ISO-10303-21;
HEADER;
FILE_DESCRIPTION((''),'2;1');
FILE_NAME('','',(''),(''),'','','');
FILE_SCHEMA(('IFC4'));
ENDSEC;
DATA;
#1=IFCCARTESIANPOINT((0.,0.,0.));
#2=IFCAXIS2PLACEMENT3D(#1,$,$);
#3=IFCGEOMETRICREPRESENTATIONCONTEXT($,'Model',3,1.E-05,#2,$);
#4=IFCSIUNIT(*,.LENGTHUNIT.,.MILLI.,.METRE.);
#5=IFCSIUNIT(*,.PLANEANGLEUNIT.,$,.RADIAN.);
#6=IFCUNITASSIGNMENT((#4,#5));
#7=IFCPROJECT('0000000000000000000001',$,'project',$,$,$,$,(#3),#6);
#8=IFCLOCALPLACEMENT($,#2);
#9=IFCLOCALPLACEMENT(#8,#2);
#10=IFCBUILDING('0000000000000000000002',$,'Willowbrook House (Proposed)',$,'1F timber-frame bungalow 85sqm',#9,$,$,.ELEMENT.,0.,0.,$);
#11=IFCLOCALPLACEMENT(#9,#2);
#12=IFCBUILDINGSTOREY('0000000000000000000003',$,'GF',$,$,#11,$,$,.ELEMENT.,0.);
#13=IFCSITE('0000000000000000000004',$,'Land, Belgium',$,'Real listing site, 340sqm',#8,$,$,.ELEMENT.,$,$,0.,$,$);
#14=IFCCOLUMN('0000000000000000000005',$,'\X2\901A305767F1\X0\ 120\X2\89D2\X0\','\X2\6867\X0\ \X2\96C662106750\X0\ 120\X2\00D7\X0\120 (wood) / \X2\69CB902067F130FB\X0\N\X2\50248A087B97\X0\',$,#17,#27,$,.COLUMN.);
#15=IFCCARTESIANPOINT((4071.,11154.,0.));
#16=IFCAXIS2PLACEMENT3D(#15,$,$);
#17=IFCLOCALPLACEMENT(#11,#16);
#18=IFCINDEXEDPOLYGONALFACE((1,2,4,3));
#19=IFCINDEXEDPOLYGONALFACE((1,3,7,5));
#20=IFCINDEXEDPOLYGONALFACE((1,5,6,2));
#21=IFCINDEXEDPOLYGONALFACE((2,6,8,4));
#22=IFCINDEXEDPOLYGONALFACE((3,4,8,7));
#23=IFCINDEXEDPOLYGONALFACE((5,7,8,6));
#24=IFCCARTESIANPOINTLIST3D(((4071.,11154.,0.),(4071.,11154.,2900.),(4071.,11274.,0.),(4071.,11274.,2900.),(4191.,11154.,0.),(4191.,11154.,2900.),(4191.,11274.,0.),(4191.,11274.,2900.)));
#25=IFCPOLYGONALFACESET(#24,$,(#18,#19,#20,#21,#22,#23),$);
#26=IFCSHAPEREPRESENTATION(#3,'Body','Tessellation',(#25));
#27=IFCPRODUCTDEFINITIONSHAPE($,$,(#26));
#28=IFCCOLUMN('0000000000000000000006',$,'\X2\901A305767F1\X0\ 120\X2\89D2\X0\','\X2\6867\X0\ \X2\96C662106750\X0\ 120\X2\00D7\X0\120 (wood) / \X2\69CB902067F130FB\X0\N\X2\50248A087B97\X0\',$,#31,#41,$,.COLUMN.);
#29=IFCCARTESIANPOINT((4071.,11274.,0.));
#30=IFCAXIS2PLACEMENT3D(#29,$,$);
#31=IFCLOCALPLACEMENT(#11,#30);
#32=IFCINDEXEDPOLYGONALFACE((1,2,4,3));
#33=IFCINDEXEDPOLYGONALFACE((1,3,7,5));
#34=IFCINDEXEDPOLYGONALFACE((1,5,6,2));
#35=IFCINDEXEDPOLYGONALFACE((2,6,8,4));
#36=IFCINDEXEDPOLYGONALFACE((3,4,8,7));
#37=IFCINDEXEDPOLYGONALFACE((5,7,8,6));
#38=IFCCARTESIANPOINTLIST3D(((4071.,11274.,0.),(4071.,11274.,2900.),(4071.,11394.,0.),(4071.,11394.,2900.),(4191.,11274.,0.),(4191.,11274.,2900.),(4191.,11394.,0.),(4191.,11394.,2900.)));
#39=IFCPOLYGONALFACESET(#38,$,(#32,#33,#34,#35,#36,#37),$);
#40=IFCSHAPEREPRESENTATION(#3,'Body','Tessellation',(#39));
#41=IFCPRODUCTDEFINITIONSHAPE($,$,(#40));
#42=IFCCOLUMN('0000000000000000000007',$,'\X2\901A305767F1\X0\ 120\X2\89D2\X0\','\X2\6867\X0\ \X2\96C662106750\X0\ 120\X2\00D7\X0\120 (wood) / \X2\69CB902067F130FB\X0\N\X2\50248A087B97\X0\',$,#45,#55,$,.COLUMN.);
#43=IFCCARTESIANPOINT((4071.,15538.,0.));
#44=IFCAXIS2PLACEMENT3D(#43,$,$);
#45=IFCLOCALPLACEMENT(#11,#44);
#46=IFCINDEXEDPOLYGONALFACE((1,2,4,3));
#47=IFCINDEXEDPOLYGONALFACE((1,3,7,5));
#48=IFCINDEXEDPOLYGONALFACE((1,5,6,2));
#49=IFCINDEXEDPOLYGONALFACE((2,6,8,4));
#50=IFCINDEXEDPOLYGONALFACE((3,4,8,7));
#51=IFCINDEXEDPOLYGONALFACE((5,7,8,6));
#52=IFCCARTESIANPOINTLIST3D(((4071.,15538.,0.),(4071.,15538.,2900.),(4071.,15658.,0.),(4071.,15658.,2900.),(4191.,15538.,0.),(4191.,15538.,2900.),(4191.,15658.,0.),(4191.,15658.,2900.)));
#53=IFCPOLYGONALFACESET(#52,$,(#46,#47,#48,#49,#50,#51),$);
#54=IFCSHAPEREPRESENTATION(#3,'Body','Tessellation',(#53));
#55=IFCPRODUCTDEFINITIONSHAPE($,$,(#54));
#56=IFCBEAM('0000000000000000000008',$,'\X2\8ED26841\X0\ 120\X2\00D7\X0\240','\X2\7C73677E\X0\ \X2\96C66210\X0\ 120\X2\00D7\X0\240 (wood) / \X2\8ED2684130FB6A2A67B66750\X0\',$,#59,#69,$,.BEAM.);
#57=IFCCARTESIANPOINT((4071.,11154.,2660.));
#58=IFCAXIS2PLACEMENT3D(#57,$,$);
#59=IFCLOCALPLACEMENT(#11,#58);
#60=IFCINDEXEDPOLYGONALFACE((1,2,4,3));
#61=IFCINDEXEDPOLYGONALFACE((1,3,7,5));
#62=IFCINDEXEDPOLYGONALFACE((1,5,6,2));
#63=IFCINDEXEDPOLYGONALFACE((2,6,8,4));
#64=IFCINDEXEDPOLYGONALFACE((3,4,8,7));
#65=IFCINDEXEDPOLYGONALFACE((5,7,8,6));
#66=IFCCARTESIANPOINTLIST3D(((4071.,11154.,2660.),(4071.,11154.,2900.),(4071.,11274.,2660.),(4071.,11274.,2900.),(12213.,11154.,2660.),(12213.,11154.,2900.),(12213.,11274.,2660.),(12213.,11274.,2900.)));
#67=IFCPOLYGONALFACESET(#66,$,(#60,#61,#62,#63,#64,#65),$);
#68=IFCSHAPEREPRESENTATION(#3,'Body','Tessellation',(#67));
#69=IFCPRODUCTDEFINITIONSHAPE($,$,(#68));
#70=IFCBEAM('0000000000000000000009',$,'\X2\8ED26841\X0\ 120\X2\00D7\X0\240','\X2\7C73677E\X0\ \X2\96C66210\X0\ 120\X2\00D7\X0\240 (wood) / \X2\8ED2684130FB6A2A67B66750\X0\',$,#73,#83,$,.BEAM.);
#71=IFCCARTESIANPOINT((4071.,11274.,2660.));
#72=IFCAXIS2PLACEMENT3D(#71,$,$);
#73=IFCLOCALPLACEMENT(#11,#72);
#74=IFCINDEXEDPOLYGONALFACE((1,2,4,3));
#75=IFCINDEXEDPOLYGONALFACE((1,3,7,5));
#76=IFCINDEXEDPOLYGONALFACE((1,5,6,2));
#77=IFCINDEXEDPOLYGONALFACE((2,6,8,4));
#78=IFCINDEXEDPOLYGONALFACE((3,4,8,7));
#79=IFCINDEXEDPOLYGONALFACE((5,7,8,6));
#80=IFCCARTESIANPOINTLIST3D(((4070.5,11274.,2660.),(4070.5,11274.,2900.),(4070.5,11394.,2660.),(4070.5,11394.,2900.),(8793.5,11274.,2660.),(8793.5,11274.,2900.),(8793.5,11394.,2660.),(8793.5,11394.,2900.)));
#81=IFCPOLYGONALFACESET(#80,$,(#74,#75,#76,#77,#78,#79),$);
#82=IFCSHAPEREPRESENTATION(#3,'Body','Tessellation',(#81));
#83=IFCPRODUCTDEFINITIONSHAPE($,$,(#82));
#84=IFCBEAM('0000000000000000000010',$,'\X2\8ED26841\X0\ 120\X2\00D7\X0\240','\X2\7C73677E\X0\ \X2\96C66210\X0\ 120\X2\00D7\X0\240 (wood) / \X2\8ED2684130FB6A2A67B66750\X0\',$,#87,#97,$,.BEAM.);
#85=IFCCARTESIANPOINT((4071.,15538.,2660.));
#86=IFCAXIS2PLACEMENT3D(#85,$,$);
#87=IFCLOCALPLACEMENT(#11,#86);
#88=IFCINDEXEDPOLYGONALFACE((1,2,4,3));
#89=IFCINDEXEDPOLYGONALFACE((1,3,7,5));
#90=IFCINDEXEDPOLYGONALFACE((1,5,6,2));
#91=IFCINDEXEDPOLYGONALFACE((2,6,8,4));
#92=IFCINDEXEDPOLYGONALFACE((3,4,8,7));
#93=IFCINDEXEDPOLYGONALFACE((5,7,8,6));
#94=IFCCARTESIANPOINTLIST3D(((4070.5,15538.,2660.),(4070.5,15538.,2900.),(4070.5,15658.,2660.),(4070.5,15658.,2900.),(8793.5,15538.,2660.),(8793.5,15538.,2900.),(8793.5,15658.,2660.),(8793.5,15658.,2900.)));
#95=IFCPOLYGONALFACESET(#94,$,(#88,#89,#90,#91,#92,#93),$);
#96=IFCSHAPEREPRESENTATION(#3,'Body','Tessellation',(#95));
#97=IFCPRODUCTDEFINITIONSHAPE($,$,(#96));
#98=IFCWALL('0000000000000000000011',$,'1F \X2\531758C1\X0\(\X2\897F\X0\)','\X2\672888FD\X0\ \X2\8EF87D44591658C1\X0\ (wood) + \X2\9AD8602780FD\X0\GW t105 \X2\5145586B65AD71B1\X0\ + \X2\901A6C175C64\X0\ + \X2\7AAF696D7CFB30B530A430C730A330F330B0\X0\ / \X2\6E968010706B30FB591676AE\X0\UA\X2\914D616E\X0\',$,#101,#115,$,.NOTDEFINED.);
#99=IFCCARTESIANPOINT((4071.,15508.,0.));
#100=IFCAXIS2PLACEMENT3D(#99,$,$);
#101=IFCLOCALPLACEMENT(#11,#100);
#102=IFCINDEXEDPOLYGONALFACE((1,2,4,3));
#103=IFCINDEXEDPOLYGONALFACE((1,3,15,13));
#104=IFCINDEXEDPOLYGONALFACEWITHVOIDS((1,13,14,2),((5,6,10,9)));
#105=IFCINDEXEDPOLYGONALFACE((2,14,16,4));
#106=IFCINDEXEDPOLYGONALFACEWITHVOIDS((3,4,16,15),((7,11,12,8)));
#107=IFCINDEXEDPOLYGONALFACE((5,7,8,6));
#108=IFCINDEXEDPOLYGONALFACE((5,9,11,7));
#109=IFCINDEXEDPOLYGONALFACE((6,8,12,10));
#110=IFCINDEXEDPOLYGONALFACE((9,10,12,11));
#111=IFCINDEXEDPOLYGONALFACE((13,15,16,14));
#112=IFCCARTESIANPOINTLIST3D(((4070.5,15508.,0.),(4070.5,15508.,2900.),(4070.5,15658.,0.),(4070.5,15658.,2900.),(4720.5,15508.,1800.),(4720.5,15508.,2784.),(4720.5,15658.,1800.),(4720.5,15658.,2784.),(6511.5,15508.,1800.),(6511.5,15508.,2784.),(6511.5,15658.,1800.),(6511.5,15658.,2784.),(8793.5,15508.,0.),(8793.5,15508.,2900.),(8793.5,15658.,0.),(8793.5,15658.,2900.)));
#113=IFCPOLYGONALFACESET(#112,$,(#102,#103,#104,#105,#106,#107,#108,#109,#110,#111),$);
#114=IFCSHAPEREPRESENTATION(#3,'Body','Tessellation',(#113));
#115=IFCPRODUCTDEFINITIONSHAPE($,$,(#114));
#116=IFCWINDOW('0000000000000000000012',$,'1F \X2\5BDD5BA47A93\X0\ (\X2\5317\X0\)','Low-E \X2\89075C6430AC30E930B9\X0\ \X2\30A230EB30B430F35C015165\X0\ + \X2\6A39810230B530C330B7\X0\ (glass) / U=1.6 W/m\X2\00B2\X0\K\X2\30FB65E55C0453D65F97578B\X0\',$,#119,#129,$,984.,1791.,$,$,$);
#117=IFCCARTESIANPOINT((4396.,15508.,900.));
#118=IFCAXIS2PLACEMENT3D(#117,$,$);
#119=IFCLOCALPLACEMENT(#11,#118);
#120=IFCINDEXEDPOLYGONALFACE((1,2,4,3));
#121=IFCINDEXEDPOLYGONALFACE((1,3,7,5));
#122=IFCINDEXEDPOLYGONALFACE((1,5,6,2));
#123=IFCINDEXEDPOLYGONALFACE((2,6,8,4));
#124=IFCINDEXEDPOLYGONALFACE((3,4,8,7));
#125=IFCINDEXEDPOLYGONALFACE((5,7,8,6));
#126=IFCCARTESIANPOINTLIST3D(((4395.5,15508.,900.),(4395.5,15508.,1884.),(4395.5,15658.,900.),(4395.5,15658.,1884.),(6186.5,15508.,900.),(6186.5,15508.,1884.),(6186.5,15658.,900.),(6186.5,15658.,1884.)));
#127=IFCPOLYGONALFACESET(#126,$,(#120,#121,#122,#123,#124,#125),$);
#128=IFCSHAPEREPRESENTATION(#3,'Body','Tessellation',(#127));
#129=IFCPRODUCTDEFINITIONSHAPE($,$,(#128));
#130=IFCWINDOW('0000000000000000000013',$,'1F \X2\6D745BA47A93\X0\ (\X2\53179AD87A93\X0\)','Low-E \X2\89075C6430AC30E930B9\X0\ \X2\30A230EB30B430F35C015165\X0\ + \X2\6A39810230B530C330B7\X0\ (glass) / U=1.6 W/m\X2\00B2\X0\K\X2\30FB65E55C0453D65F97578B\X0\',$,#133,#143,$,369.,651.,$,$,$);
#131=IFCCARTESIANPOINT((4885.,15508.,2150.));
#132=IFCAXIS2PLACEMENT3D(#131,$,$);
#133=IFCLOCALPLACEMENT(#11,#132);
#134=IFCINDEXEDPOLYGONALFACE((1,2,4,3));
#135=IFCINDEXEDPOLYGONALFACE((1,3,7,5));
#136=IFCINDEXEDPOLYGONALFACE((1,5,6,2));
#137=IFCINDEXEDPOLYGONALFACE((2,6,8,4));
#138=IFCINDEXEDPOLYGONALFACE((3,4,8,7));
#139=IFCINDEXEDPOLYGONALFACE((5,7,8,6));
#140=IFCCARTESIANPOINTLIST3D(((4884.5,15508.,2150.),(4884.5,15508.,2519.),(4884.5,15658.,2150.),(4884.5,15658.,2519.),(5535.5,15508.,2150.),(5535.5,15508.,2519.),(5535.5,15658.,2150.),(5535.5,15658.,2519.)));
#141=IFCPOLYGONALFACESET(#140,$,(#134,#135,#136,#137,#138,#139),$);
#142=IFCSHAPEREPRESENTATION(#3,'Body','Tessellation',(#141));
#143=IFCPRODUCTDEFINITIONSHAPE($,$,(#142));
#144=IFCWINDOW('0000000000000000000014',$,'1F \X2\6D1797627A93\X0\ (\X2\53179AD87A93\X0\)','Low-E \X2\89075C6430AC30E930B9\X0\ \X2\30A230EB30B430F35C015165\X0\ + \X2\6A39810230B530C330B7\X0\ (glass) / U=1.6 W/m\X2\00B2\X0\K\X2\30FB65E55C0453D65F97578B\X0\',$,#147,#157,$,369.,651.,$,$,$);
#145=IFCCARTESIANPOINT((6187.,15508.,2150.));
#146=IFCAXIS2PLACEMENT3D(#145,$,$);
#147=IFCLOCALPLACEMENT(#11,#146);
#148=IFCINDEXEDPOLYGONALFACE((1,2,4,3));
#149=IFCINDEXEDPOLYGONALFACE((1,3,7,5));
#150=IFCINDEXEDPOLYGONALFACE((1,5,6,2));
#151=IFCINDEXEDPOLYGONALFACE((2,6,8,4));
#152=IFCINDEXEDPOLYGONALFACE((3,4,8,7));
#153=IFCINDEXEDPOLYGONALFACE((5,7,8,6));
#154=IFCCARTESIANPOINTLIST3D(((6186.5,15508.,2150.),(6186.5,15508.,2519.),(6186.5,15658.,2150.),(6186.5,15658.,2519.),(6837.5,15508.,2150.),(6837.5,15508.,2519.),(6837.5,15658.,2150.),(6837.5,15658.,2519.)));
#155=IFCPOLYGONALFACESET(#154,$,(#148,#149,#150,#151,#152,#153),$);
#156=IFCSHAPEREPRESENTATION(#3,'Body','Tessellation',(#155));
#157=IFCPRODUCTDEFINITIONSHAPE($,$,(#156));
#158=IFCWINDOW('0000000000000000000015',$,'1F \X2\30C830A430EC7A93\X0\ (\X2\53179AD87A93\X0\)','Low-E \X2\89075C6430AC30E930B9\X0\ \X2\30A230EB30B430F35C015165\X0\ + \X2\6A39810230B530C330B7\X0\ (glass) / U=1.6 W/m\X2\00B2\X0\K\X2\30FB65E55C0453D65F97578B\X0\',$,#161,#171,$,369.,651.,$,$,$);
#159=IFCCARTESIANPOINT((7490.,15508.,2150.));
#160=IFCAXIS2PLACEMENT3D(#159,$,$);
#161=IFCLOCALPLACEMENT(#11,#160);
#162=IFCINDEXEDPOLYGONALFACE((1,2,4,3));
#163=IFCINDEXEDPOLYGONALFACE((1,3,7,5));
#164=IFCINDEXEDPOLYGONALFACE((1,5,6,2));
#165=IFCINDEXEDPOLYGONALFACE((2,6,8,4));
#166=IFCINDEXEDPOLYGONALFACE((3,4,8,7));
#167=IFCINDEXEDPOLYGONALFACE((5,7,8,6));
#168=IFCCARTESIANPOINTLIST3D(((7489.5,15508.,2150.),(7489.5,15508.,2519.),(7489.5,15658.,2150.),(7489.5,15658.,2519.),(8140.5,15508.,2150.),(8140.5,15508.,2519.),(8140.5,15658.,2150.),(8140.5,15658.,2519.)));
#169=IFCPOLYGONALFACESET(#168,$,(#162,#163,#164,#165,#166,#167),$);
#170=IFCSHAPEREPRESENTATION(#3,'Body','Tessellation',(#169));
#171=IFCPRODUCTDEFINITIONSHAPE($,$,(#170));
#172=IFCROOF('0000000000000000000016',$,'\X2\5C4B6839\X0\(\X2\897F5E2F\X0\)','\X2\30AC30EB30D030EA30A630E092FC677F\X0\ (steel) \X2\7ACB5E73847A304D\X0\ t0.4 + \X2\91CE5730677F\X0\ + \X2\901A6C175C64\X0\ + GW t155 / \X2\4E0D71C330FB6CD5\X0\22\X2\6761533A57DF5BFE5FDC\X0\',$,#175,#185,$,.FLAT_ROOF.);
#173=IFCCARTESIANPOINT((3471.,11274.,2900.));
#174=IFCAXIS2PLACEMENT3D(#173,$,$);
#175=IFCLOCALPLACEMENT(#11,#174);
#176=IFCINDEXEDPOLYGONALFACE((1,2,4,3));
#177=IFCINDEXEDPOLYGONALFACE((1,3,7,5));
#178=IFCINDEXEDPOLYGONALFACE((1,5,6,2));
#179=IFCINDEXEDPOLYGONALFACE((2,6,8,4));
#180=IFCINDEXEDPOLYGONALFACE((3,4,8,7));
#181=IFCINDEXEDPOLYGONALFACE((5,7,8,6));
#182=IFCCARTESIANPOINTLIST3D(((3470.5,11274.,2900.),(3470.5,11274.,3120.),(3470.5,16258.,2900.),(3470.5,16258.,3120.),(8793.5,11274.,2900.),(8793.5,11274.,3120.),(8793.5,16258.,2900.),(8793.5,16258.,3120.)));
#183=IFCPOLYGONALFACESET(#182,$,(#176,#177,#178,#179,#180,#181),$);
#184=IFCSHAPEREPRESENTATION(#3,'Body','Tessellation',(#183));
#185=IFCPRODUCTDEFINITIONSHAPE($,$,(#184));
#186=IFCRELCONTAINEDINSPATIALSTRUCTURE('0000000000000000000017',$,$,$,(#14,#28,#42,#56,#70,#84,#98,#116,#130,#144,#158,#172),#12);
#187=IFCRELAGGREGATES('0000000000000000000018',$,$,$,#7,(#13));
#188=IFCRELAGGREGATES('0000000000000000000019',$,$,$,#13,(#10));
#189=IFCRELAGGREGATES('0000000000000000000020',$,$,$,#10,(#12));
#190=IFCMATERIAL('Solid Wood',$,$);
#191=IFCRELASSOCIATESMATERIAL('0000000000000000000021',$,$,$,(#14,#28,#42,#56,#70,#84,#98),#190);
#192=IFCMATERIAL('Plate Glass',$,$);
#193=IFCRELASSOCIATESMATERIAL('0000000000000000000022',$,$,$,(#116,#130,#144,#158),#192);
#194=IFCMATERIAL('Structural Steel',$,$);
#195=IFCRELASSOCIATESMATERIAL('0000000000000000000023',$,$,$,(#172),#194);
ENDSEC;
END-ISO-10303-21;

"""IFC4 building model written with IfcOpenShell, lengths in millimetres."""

from ifc_helpers import new_model, si_unit, frame, frame_2d, origin, place, context, project, spatial, rectangle, extrude, material, element, fill, save


model = new_model("IFC4")

# Units and contexts
model_context = context("Model", 3, precision=1e-05, world=origin())
ifc_project = project(units=[si_unit("LENGTHUNIT", "METRE", prefix="MILLI"), si_unit("PLANEANGLEUNIT", "RADIAN")], contexts=[model_context])

# Site, building, storey
site_placement = place(None, origin())
site = spatial("IfcSite", under=ifc_project, at=site_placement, Name="Land, Belgium", ObjectType="Real listing site, 340sqm", CompositionType="ELEMENT", RefElevation=0.0)
building_placement = place(site_placement, origin())
building = spatial("IfcBuilding", under=site, at=building_placement, Name="Willowbrook House (Proposed)", ObjectType="1F timber-frame bungalow 85sqm", CompositionType="ELEMENT", ElevationOfRefHeight=0.0, ElevationOfTerrain=0.0)
storey_placement = place(building_placement, origin())
storey = spatial("IfcBuildingStorey", under=building, at=storey_placement, Name="GF", CompositionType="ELEMENT", Elevation=0.0)

# Columns
ifc_material_1 = material(Name="Solid Wood")
column_1_placement = place(storey_placement, frame((4071.0, 11154.0, 0.0)))
element("IfcColumn", 1, at=column_1_placement, inside=storey, material=ifc_material_1, Name="通し柱 120角", Description="桧 集成材 120×120 (wood) / 構造柱・N値計算", PredefinedType="COLUMN", context=model_context, shape_type="SweptSolid", body=[
    extrude(rectangle(XDim=120.0, YDim=120.0, at=frame_2d((60.0, 60.0))), frame((4071.0, 11154.0, 0.0)), (0.0, 0.0, 1.0), 2900.0),
])
column_2_placement = place(storey_placement, frame((4071.0, 11274.0, 0.0)))
element("IfcColumn", 2, at=column_2_placement, inside=storey, material=ifc_material_1, Name="通し柱 120角", Description="桧 集成材 120×120 (wood) / 構造柱・N値計算", PredefinedType="COLUMN", context=model_context, shape_type="SweptSolid", body=[
    extrude(rectangle(XDim=120.0, YDim=120.0, at=frame_2d((60.0, 60.0))), frame((4071.0, 11274.0, 0.0)), (0.0, 0.0, 1.0), 2900.0),
])
column_3_placement = place(storey_placement, frame((4071.0, 15538.0, 0.0)))
element("IfcColumn", 3, at=column_3_placement, inside=storey, material=ifc_material_1, Name="通し柱 120角", Description="桧 集成材 120×120 (wood) / 構造柱・N値計算", PredefinedType="COLUMN", context=model_context, shape_type="SweptSolid", body=[
    extrude(rectangle(XDim=120.0, YDim=120.0, at=frame_2d((60.0, 60.0))), frame((4071.0, 15538.0, 0.0)), (0.0, 0.0, 1.0), 2900.0),
])

# Beams
beam_1_placement = place(storey_placement, frame((4071.0, 11154.0, 2660.0)))
element("IfcBeam", 4, at=beam_1_placement, inside=storey, material=ifc_material_1, Name="軒桁 120×240", Description="米松 集成 120×240 (wood) / 軒桁・横架材", PredefinedType="BEAM", context=model_context, shape_type="SweptSolid", body=[
    extrude(rectangle(XDim=8142.0, YDim=120.0, at=frame_2d((4071.0, 60.0))), frame((4071.0, 11154.0, 2660.0)), (0.0, 0.0, 1.0), 240.0),
])
beam_2_placement = place(storey_placement, frame((4071.0, 11274.0, 2660.0)))
element("IfcBeam", 5, at=beam_2_placement, inside=storey, material=ifc_material_1, Name="軒桁 120×240", Description="米松 集成 120×240 (wood) / 軒桁・横架材", PredefinedType="BEAM", context=model_context, shape_type="SweptSolid", body=[
    extrude(rectangle(XDim=4723.0, YDim=120.0, at=frame_2d((2361.0, 60.0))), frame((4071.0, 11274.0, 2660.0)), (0.0, 0.0, 1.0), 240.0),
])
beam_3_placement = place(storey_placement, frame((4071.0, 15538.0, 2660.0)))
element("IfcBeam", 6, at=beam_3_placement, inside=storey, material=ifc_material_1, Name="軒桁 120×240", Description="米松 集成 120×240 (wood) / 軒桁・横架材", PredefinedType="BEAM", context=model_context, shape_type="SweptSolid", body=[
    extrude(rectangle(XDim=4723.0, YDim=120.0, at=frame_2d((2361.0, 60.0))), frame((4071.0, 15538.0, 2660.0)), (0.0, 0.0, 1.0), 240.0),
])

# Wall, openings, windows
wall_1_placement = place(storey_placement, frame((4071.0, 15508.0, 0.0)))
wall_1 = element("IfcWall", 7, at=wall_1_placement, inside=storey, material=ifc_material_1, Name="1F 北壁(西)", Description="木製 軸組外壁 (wood) + 高性能GW t105 充填断熱 + 通気層 + 窯業系サイディング / 準耐火・外皮UA配慮", PredefinedType="NOTDEFINED", context=model_context, shape_type="SweptSolid", body=[
    extrude(rectangle(XDim=4723.0, YDim=150.0, at=frame_2d((2361.0, 75.0))), frame((4071.0, 15508.0, 0.0)), (0.0, 0.0, 1.0), 2900.0),
])
opening_1_placement = place(storey_placement, frame((4396.0, 15508.0, 900.0)))
opening_1 = element("IfcOpeningElement", 8, at=opening_1_placement, cuts=wall_1, PredefinedType="NOTDEFINED", context=model_context, shape_type="SweptSolid", body=[
    extrude(rectangle(XDim=1791.0, YDim=150.0, at=frame_2d((895.0, 75.0))), frame((4396.0, 15508.0, 900.0)), (0.0, 0.0, 1.0), 984.0),
])
opening_2_placement = place(storey_placement, frame((4885.0, 15508.0, 2150.0)))
opening_2 = element("IfcOpeningElement", 9, at=opening_2_placement, cuts=wall_1, PredefinedType="NOTDEFINED", context=model_context, shape_type="SweptSolid", body=[
    extrude(rectangle(XDim=651.0, YDim=150.0, at=frame_2d((325.0, 75.0))), frame((4885.0, 15508.0, 2150.0)), (0.0, 0.0, 1.0), 369.0),
])
opening_3_placement = place(storey_placement, frame((6187.0, 15508.0, 2150.0)))
opening_3 = element("IfcOpeningElement", 10, at=opening_3_placement, cuts=wall_1, PredefinedType="NOTDEFINED", context=model_context, shape_type="SweptSolid", body=[
    extrude(rectangle(XDim=651.0, YDim=150.0, at=frame_2d((325.0, 75.0))), frame((6187.0, 15508.0, 2150.0)), (0.0, 0.0, 1.0), 369.0),
])
opening_4_placement = place(storey_placement, frame((7490.0, 15508.0, 2150.0)))
opening_4 = element("IfcOpeningElement", 11, at=opening_4_placement, cuts=wall_1, PredefinedType="NOTDEFINED", context=model_context, shape_type="SweptSolid", body=[
    extrude(rectangle(XDim=651.0, YDim=150.0, at=frame_2d((325.0, 75.0))), frame((7490.0, 15508.0, 2150.0)), (0.0, 0.0, 1.0), 369.0),
])
ifc_material_2 = material(Name="Plate Glass")
window_1_placement = place(storey_placement, frame((4396.0, 15508.0, 900.0)))
window_1 = element("IfcWindow", 12, at=window_1_placement, inside=storey, material=ifc_material_2, Name="1F 寝室窓 (北)", Description="Low-E 複層ガラス アルゴン封入 + 樹脂サッシ (glass) / U=1.6 W/m²K・日射取得型", OverallHeight=984.0, OverallWidth=1791.0, context=model_context, shape_type="SweptSolid", body=[
    extrude(rectangle(XDim=1791.0, YDim=150.0, at=frame_2d((895.0, 75.0))), frame((4396.0, 15508.0, 900.0)), (0.0, 0.0, 1.0), 984.0),
])
fill(opening_1, window_1)
window_2_placement = place(storey_placement, frame((4885.0, 15508.0, 2150.0)))
window_2 = element("IfcWindow", 13, at=window_2_placement, inside=storey, material=ifc_material_2, Name="1F 浴室窓 (北高窓)", Description="Low-E 複層ガラス アルゴン封入 + 樹脂サッシ (glass) / U=1.6 W/m²K・日射取得型", OverallHeight=369.0, OverallWidth=651.0, context=model_context, shape_type="SweptSolid", body=[
    extrude(rectangle(XDim=651.0, YDim=150.0, at=frame_2d((325.0, 75.0))), frame((4885.0, 15508.0, 2150.0)), (0.0, 0.0, 1.0), 369.0),
])
fill(opening_2, window_2)
window_3_placement = place(storey_placement, frame((6187.0, 15508.0, 2150.0)))
window_3 = element("IfcWindow", 14, at=window_3_placement, inside=storey, material=ifc_material_2, Name="1F 洗面窓 (北高窓)", Description="Low-E 複層ガラス アルゴン封入 + 樹脂サッシ (glass) / U=1.6 W/m²K・日射取得型", OverallHeight=369.0, OverallWidth=651.0, context=model_context, shape_type="SweptSolid", body=[
    extrude(rectangle(XDim=651.0, YDim=150.0, at=frame_2d((325.0, 75.0))), frame((6187.0, 15508.0, 2150.0)), (0.0, 0.0, 1.0), 369.0),
])
fill(opening_3, window_3)
window_4_placement = place(storey_placement, frame((7490.0, 15508.0, 2150.0)))
window_4 = element("IfcWindow", 15, at=window_4_placement, inside=storey, material=ifc_material_2, Name="1F トイレ窓 (北高窓)", Description="Low-E 複層ガラス アルゴン封入 + 樹脂サッシ (glass) / U=1.6 W/m²K・日射取得型", OverallHeight=369.0, OverallWidth=651.0, context=model_context, shape_type="SweptSolid", body=[
    extrude(rectangle(XDim=651.0, YDim=150.0, at=frame_2d((325.0, 75.0))), frame((7490.0, 15508.0, 2150.0)), (0.0, 0.0, 1.0), 369.0),
])
fill(opening_4, window_4)

# Roof
ifc_material_3 = material(Name="Structural Steel")
roof_placement = place(storey_placement, frame((3471.0, 11274.0, 2900.0)))
element("IfcRoof", 16, at=roof_placement, inside=storey, material=ifc_material_3, Name="屋根(西帯)", Description="ガルバリウム鋼板 (steel) 立平葺き t0.4 + 野地板 + 通気層 + GW t155 / 不燃・法22条区域対応", PredefinedType="FLAT_ROOF", context=model_context, shape_type="SweptSolid", body=[
    extrude(rectangle(XDim=5323.0, YDim=4984.0, at=frame_2d((2661.0, 2492.0))), frame((3471.0, 11274.0, 2900.0)), (0.0, 0.0, 1.0), 220.0),
])

save(model, "model.ifc")
